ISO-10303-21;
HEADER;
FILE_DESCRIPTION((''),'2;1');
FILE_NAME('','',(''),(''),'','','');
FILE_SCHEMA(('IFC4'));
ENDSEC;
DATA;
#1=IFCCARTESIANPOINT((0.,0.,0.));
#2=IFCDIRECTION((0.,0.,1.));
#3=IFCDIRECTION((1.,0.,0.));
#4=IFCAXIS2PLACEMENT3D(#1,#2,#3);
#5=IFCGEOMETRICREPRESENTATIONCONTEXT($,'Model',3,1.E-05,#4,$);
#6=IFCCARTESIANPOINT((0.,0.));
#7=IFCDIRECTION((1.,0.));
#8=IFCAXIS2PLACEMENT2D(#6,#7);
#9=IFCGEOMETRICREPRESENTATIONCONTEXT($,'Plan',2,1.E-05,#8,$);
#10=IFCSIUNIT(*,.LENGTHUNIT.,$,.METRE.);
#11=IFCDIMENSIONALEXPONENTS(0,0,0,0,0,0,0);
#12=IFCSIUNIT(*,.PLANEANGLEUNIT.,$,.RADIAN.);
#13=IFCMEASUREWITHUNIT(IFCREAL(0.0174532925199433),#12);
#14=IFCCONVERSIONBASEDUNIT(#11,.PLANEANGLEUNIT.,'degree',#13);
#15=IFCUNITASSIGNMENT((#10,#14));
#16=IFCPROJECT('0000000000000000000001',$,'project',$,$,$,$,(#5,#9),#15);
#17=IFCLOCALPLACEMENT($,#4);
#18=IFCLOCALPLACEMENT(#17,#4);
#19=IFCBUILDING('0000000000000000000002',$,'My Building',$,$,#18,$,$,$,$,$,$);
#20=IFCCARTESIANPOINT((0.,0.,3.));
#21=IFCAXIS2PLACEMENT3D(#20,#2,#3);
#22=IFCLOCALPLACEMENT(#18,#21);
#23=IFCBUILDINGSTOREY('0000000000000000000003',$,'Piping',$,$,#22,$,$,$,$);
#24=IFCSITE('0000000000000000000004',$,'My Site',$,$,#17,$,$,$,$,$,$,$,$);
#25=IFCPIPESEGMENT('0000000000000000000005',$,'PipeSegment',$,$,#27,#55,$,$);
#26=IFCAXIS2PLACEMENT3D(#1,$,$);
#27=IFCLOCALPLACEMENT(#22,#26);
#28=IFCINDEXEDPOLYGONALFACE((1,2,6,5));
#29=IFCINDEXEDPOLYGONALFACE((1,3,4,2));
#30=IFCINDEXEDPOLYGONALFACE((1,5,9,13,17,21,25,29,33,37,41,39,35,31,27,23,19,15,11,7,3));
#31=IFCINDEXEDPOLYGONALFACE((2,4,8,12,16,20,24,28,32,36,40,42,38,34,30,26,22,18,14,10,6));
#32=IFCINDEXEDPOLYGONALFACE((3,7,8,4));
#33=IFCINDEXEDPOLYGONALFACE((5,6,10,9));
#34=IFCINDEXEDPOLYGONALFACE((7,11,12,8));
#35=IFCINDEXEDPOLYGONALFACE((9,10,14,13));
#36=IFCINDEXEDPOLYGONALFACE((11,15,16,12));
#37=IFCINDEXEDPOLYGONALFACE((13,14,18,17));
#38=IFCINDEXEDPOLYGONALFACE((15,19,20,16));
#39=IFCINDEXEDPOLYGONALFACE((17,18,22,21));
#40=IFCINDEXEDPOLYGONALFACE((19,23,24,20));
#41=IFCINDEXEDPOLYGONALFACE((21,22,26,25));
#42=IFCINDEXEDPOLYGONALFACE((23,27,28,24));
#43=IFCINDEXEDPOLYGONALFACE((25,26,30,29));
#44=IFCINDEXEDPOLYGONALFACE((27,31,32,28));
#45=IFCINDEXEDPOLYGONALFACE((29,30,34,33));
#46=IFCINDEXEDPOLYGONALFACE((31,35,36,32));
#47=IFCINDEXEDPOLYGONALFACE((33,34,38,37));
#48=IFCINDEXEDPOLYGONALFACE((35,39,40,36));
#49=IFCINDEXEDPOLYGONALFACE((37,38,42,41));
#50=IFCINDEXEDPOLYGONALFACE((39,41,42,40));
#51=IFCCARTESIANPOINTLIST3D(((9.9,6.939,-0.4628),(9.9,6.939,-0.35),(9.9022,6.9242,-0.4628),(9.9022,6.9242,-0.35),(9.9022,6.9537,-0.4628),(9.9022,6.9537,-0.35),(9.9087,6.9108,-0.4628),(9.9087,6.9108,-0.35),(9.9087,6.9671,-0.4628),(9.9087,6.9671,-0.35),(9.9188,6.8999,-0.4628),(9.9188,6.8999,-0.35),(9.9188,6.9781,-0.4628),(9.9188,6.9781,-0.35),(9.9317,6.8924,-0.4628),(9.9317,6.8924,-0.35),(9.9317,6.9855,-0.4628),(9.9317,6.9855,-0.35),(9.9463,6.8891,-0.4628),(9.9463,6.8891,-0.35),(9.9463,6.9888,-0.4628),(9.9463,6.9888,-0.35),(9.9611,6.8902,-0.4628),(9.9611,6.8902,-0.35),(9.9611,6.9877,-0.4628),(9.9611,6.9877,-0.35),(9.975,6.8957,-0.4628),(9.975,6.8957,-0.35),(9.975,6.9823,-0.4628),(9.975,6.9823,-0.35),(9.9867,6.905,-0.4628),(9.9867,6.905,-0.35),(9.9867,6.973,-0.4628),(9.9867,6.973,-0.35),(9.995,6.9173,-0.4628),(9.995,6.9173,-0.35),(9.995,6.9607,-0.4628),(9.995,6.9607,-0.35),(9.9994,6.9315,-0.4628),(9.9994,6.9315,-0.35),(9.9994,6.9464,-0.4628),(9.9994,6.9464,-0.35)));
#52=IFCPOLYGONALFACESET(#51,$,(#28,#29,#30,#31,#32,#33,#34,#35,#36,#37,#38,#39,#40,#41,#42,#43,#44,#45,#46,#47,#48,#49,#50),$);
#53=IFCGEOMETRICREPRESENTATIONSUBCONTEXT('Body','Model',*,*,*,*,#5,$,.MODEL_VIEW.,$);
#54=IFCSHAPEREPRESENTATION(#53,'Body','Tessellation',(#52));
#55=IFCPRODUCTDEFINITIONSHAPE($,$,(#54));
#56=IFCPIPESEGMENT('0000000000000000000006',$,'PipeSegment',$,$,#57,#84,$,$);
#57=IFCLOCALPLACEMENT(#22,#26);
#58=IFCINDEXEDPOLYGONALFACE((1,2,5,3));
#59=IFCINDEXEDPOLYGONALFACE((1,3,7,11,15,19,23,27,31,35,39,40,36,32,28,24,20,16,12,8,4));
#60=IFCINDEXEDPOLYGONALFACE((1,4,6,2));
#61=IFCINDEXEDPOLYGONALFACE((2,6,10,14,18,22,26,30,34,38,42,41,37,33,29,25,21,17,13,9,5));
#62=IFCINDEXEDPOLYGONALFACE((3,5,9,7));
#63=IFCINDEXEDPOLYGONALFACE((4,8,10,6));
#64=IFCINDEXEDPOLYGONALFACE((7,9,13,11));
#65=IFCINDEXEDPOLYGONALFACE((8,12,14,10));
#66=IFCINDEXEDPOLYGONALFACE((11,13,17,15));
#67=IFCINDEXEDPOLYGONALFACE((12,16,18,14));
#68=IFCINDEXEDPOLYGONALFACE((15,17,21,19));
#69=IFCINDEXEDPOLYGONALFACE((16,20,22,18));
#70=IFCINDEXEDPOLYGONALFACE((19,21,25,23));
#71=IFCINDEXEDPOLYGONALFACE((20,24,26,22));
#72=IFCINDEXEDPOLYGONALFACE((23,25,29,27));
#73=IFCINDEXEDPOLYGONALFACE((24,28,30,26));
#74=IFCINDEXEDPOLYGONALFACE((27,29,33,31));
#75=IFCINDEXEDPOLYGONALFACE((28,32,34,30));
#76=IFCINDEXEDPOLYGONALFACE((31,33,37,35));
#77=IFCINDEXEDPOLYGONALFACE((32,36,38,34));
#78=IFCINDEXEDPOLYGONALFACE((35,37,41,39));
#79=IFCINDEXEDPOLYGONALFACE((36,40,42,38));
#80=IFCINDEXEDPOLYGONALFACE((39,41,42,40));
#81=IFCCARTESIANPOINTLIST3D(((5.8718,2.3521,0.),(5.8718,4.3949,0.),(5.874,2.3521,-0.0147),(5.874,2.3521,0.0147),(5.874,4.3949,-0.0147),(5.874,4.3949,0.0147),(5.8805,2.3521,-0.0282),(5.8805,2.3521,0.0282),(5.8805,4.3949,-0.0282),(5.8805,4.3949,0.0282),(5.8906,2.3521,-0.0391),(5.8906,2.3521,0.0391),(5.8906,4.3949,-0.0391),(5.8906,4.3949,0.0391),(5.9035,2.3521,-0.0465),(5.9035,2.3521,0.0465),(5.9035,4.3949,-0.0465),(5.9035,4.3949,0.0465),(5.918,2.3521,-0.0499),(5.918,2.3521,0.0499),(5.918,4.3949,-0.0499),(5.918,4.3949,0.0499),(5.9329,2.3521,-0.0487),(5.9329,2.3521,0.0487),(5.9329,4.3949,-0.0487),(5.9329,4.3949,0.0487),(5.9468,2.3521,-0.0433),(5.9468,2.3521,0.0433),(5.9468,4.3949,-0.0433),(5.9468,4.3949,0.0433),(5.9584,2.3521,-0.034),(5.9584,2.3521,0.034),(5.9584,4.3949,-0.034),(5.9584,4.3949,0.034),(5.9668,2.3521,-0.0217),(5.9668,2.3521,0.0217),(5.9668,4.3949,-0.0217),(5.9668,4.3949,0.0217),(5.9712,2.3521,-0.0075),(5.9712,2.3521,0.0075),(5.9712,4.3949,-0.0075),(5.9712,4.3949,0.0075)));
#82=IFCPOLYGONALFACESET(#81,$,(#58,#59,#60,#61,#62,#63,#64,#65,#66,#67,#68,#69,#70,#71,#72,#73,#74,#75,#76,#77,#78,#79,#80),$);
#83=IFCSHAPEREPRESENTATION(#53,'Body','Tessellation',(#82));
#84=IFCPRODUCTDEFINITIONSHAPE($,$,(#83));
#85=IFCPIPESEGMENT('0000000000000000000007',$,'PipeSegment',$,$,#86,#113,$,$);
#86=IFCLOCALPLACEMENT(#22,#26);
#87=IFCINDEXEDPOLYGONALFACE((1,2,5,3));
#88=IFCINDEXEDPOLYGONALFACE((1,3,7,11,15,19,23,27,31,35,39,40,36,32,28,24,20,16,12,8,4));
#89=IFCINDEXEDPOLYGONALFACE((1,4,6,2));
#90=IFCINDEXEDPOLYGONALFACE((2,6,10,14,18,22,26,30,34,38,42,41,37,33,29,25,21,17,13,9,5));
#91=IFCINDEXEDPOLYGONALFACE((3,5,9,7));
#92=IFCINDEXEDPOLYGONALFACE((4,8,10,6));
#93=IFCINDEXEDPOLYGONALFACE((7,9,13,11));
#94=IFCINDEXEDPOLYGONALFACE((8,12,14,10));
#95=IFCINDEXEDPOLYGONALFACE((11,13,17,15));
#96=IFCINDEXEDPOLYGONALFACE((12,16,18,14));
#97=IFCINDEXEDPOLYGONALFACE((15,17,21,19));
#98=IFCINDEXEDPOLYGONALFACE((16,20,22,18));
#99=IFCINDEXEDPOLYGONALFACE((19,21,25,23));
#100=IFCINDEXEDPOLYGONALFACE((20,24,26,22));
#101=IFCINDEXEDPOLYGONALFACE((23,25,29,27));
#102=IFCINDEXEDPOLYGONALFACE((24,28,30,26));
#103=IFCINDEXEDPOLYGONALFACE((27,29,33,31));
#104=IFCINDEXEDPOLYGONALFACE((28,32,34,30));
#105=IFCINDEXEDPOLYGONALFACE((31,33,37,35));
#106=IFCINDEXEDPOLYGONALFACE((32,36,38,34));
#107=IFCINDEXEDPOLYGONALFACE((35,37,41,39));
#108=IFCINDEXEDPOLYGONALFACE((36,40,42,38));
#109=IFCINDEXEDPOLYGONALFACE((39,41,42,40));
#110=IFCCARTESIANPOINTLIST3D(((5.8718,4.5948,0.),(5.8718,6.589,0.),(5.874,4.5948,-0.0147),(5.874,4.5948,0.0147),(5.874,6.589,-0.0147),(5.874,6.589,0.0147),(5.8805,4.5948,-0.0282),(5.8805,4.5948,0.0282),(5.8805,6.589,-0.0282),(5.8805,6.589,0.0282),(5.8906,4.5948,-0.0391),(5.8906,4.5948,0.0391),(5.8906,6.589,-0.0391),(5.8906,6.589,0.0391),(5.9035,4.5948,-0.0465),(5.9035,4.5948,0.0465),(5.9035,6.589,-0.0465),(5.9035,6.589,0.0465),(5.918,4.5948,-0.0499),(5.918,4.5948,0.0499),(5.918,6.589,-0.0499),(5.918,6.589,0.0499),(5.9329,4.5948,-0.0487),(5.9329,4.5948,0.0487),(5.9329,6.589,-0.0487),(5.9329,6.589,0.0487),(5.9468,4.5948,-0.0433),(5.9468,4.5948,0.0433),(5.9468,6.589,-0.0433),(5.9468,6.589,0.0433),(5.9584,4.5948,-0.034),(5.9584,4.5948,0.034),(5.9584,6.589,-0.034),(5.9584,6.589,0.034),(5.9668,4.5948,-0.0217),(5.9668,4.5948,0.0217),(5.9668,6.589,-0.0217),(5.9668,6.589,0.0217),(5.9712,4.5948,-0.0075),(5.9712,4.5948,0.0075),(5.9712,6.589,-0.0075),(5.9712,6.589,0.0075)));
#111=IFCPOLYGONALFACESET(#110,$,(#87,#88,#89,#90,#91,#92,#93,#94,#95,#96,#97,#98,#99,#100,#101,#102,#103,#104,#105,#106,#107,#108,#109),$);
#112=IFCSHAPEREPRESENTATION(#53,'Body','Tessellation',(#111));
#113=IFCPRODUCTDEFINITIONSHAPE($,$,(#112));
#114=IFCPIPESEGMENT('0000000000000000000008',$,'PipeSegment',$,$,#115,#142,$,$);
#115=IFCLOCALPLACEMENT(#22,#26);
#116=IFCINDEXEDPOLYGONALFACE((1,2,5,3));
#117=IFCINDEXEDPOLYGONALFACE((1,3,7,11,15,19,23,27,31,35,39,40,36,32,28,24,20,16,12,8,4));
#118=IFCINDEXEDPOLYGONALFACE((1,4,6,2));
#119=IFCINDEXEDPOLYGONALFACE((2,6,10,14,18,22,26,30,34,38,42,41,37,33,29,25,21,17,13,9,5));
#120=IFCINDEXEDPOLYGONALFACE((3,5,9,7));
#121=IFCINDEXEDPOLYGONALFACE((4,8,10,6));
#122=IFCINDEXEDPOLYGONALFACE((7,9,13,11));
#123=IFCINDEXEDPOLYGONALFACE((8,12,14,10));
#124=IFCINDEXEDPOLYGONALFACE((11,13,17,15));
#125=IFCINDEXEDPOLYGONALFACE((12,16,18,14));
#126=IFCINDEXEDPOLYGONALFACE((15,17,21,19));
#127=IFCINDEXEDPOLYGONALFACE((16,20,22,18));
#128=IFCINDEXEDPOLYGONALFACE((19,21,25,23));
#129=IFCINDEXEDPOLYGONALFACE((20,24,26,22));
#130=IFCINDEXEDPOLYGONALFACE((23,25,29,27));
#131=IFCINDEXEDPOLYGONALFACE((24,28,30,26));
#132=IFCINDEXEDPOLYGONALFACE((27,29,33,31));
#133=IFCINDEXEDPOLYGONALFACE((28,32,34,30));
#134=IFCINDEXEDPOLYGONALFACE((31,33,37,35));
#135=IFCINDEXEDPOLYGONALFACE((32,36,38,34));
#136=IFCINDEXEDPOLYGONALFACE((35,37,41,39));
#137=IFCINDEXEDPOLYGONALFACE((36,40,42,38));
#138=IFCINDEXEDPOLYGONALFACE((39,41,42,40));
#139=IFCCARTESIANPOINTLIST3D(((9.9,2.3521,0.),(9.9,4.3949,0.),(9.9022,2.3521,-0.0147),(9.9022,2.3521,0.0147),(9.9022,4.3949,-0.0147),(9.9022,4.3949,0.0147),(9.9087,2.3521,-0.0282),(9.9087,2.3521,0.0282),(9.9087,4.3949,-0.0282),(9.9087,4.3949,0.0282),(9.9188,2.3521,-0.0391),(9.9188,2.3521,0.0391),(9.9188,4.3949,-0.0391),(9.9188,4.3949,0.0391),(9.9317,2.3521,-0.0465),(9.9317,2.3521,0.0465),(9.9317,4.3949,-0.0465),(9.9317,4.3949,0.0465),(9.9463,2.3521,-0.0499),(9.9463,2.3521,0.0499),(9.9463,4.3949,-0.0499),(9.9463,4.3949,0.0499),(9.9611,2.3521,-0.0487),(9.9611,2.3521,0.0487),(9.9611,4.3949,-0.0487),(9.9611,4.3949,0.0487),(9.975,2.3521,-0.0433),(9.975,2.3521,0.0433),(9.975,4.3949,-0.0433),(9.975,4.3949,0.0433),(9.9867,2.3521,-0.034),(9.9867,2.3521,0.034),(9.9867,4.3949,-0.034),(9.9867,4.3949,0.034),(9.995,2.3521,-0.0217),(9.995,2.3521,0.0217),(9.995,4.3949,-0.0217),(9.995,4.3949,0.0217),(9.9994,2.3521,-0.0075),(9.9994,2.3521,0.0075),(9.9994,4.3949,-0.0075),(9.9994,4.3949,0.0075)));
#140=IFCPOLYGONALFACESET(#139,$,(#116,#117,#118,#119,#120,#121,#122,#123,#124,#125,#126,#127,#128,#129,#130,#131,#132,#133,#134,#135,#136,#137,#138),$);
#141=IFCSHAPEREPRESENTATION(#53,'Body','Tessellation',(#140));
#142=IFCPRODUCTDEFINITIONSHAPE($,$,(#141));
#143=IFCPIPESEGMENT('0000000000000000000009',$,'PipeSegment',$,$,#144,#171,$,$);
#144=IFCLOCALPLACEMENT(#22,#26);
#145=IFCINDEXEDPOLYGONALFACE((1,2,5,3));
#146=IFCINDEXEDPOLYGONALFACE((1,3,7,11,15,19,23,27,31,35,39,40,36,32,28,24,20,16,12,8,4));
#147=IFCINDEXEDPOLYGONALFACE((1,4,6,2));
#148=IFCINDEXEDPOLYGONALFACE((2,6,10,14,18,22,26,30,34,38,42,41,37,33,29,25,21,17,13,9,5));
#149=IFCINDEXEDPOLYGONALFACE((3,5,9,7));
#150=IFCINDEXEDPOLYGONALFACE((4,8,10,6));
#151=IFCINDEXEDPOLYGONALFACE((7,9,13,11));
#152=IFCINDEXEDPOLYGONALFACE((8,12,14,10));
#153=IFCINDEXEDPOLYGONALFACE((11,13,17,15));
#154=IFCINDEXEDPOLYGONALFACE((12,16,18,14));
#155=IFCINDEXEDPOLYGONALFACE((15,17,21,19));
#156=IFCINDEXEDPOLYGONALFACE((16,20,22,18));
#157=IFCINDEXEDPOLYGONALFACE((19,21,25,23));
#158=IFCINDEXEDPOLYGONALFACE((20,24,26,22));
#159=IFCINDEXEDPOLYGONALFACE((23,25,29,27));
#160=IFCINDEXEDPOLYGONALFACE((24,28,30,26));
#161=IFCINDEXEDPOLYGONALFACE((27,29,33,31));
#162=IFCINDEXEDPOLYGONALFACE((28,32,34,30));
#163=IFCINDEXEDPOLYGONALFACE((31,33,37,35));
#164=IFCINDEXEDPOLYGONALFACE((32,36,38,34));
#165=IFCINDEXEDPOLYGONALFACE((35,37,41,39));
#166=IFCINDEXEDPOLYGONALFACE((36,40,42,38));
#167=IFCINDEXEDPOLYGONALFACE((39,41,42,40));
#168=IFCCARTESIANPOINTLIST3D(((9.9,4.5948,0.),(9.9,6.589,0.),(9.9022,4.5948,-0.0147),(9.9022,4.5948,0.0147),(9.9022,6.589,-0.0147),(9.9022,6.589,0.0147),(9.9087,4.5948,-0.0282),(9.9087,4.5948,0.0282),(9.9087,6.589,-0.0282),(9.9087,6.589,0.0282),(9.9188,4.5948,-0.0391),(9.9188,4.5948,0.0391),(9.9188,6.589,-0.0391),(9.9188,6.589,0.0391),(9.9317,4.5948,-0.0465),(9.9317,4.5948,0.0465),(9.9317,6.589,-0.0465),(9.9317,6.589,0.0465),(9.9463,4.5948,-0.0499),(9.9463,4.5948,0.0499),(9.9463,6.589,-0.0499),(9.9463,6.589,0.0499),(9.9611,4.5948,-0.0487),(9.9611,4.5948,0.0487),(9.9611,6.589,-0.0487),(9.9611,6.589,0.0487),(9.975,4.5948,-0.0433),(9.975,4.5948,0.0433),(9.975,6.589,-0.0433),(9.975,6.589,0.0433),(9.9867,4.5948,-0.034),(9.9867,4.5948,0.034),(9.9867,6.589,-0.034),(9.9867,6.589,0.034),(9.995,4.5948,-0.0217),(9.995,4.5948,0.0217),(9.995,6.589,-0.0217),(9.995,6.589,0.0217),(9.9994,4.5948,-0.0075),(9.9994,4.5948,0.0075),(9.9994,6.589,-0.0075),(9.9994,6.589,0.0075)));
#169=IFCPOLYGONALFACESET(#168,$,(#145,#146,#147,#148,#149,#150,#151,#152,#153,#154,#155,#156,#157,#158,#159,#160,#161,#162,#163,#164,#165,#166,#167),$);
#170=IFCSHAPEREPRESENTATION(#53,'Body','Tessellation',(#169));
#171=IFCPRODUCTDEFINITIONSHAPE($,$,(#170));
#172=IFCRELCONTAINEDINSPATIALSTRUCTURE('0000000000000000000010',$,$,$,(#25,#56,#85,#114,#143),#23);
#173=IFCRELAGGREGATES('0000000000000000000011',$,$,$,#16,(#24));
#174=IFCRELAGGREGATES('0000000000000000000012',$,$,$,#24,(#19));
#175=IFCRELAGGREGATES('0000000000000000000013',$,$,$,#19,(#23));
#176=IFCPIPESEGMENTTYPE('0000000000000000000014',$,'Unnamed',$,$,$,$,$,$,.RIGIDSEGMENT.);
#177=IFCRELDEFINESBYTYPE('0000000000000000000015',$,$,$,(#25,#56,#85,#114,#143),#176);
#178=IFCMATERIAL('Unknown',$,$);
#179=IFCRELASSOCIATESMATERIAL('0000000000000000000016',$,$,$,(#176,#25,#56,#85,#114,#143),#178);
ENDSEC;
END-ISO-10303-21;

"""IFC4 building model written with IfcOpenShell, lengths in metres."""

from ifc_helpers import new_model, entity, si_unit, converted_unit, frame, origin_with_axes, origin_2d_with_axis, place, context, subcontext, project, spatial, circle, extrude, material, material_profile, profile_set, profile_usage, type_object, element, save


model = new_model("IFC4")

# Units and contexts
model_context = context("Model", 3, precision=1e-05, world=origin_with_axes())
plan_context = context("Plan", 2, precision=1e-05, world=origin_2d_with_axis())
body_context = subcontext(model_context, "Body", "Model", "MODEL_VIEW")
ifc_project = project(units=[si_unit("LENGTHUNIT", "METRE"), converted_unit("PLANEANGLEUNIT", "degree", entity("IfcReal", 0.0174532925199433), si_unit("PLANEANGLEUNIT", "RADIAN"), dimensions=[0, 0, 0, 0, 0, 0, 0])], contexts=[model_context, plan_context])

# Site, building, storey
site_placement = place(None, origin_with_axes())
site = spatial("IfcSite", under=ifc_project, at=site_placement, Name="My Site")
building_placement = place(site_placement, origin_with_axes())
building = spatial("IfcBuilding", under=site, at=building_placement, Name="My Building")
storey_placement = place(building_placement, frame((0.0, 0.0, 3.0), z_axis=(0.0, 0.0, 1.0), x_axis=(1.0, 0.0, 0.0)))
storey = spatial("IfcBuildingStorey", under=building, at=storey_placement, Name="Piping")

# Pipe segments
ifc_material = material(Name="Unknown")
ifc_material_profile_1 = material_profile(ifc_material, circle(Radius=0.05))
ifc_profile_set_1 = profile_set([ifc_material_profile_1])
pipe_segment_type = type_object("IfcPipeSegmentType", Name="Unnamed", PredefinedType="RIGIDSEGMENT", material=ifc_profile_set_1)
ifc_profile_usage_1 = profile_usage(ifc_profile_set_1, cardinal=5)
pipe_segment_1_placement = place(storey_placement, frame((9.95, 6.939, -0.35), z_axis=(0.0, 0.0, -1.0), x_axis=(-1.0, 0.0, 0.0)))
element("IfcPipeSegment", 1, at=pipe_segment_1_placement, inside=storey, type_object=pipe_segment_type, material=ifc_profile_usage_1, Name="PipeSegment", context=body_context, shape_type="SweptSolid", body=[
    extrude(circle(Radius=0.05), origin_with_axes(), (0.0, 0.0, 1.0), 0.1128),
])
ifc_profile_usage_2 = profile_usage(ifc_profile_set_1, cardinal=5)
pipe_segment_2_placement = place(storey_placement, frame((5.9218, 2.3521, 0.0), z_axis=(0.0, 1.0, 0.0), x_axis=(-1.0, 0.0, 0.0)))
element("IfcPipeSegment", 2, at=pipe_segment_2_placement, inside=storey, type_object=pipe_segment_type, material=ifc_profile_usage_2, Name="PipeSegment", context=body_context, shape_type="SweptSolid", body=[
    extrude(circle(Radius=0.05), origin_with_axes(), (0.0, 0.0, 1.0), 2.0428),
])
ifc_profile_usage_3 = profile_usage(ifc_profile_set_1, cardinal=5)
pipe_segment_3_placement = place(storey_placement, frame((5.9218, 4.5948, 0.0), z_axis=(0.0, 1.0, 0.0), x_axis=(-1.0, 0.0, 0.0)))
element("IfcPipeSegment", 3, at=pipe_segment_3_placement, inside=storey, type_object=pipe_segment_type, material=ifc_profile_usage_3, Name="PipeSegment", context=body_context, shape_type="SweptSolid", body=[
    extrude(circle(Radius=0.05), origin_with_axes(), (0.0, 0.0, 1.0), 1.9942),
])
ifc_profile_usage_4 = profile_usage(ifc_profile_set_1, cardinal=5)
pipe_segment_4_placement = place(storey_placement, frame((9.95, 2.3521, 0.0), z_axis=(0.0, 1.0, 0.0), x_axis=(-1.0, 0.0, 0.0)))
element("IfcPipeSegment", 4, at=pipe_segment_4_placement, inside=storey, type_object=pipe_segment_type, material=ifc_profile_usage_4, Name="PipeSegment", context=body_context, shape_type="SweptSolid", body=[
    extrude(circle(Radius=0.05), origin_with_axes(), (0.0, 0.0, 1.0), 2.0428),
])
ifc_profile_usage_5 = profile_usage(ifc_profile_set_1, cardinal=5)
pipe_segment_5_placement = place(storey_placement, frame((9.95, 4.5948, 0.0), z_axis=(0.0, 1.0, 0.0), x_axis=(-1.0, 0.0, 0.0)))
element("IfcPipeSegment", 5, at=pipe_segment_5_placement, inside=storey, type_object=pipe_segment_type, material=ifc_profile_usage_5, Name="PipeSegment", context=body_context, shape_type="SweptSolid", body=[
    extrude(circle(Radius=0.05), origin_with_axes(), (0.0, 0.0, 1.0), 1.9942),
])

save(model, "model.ifc")
